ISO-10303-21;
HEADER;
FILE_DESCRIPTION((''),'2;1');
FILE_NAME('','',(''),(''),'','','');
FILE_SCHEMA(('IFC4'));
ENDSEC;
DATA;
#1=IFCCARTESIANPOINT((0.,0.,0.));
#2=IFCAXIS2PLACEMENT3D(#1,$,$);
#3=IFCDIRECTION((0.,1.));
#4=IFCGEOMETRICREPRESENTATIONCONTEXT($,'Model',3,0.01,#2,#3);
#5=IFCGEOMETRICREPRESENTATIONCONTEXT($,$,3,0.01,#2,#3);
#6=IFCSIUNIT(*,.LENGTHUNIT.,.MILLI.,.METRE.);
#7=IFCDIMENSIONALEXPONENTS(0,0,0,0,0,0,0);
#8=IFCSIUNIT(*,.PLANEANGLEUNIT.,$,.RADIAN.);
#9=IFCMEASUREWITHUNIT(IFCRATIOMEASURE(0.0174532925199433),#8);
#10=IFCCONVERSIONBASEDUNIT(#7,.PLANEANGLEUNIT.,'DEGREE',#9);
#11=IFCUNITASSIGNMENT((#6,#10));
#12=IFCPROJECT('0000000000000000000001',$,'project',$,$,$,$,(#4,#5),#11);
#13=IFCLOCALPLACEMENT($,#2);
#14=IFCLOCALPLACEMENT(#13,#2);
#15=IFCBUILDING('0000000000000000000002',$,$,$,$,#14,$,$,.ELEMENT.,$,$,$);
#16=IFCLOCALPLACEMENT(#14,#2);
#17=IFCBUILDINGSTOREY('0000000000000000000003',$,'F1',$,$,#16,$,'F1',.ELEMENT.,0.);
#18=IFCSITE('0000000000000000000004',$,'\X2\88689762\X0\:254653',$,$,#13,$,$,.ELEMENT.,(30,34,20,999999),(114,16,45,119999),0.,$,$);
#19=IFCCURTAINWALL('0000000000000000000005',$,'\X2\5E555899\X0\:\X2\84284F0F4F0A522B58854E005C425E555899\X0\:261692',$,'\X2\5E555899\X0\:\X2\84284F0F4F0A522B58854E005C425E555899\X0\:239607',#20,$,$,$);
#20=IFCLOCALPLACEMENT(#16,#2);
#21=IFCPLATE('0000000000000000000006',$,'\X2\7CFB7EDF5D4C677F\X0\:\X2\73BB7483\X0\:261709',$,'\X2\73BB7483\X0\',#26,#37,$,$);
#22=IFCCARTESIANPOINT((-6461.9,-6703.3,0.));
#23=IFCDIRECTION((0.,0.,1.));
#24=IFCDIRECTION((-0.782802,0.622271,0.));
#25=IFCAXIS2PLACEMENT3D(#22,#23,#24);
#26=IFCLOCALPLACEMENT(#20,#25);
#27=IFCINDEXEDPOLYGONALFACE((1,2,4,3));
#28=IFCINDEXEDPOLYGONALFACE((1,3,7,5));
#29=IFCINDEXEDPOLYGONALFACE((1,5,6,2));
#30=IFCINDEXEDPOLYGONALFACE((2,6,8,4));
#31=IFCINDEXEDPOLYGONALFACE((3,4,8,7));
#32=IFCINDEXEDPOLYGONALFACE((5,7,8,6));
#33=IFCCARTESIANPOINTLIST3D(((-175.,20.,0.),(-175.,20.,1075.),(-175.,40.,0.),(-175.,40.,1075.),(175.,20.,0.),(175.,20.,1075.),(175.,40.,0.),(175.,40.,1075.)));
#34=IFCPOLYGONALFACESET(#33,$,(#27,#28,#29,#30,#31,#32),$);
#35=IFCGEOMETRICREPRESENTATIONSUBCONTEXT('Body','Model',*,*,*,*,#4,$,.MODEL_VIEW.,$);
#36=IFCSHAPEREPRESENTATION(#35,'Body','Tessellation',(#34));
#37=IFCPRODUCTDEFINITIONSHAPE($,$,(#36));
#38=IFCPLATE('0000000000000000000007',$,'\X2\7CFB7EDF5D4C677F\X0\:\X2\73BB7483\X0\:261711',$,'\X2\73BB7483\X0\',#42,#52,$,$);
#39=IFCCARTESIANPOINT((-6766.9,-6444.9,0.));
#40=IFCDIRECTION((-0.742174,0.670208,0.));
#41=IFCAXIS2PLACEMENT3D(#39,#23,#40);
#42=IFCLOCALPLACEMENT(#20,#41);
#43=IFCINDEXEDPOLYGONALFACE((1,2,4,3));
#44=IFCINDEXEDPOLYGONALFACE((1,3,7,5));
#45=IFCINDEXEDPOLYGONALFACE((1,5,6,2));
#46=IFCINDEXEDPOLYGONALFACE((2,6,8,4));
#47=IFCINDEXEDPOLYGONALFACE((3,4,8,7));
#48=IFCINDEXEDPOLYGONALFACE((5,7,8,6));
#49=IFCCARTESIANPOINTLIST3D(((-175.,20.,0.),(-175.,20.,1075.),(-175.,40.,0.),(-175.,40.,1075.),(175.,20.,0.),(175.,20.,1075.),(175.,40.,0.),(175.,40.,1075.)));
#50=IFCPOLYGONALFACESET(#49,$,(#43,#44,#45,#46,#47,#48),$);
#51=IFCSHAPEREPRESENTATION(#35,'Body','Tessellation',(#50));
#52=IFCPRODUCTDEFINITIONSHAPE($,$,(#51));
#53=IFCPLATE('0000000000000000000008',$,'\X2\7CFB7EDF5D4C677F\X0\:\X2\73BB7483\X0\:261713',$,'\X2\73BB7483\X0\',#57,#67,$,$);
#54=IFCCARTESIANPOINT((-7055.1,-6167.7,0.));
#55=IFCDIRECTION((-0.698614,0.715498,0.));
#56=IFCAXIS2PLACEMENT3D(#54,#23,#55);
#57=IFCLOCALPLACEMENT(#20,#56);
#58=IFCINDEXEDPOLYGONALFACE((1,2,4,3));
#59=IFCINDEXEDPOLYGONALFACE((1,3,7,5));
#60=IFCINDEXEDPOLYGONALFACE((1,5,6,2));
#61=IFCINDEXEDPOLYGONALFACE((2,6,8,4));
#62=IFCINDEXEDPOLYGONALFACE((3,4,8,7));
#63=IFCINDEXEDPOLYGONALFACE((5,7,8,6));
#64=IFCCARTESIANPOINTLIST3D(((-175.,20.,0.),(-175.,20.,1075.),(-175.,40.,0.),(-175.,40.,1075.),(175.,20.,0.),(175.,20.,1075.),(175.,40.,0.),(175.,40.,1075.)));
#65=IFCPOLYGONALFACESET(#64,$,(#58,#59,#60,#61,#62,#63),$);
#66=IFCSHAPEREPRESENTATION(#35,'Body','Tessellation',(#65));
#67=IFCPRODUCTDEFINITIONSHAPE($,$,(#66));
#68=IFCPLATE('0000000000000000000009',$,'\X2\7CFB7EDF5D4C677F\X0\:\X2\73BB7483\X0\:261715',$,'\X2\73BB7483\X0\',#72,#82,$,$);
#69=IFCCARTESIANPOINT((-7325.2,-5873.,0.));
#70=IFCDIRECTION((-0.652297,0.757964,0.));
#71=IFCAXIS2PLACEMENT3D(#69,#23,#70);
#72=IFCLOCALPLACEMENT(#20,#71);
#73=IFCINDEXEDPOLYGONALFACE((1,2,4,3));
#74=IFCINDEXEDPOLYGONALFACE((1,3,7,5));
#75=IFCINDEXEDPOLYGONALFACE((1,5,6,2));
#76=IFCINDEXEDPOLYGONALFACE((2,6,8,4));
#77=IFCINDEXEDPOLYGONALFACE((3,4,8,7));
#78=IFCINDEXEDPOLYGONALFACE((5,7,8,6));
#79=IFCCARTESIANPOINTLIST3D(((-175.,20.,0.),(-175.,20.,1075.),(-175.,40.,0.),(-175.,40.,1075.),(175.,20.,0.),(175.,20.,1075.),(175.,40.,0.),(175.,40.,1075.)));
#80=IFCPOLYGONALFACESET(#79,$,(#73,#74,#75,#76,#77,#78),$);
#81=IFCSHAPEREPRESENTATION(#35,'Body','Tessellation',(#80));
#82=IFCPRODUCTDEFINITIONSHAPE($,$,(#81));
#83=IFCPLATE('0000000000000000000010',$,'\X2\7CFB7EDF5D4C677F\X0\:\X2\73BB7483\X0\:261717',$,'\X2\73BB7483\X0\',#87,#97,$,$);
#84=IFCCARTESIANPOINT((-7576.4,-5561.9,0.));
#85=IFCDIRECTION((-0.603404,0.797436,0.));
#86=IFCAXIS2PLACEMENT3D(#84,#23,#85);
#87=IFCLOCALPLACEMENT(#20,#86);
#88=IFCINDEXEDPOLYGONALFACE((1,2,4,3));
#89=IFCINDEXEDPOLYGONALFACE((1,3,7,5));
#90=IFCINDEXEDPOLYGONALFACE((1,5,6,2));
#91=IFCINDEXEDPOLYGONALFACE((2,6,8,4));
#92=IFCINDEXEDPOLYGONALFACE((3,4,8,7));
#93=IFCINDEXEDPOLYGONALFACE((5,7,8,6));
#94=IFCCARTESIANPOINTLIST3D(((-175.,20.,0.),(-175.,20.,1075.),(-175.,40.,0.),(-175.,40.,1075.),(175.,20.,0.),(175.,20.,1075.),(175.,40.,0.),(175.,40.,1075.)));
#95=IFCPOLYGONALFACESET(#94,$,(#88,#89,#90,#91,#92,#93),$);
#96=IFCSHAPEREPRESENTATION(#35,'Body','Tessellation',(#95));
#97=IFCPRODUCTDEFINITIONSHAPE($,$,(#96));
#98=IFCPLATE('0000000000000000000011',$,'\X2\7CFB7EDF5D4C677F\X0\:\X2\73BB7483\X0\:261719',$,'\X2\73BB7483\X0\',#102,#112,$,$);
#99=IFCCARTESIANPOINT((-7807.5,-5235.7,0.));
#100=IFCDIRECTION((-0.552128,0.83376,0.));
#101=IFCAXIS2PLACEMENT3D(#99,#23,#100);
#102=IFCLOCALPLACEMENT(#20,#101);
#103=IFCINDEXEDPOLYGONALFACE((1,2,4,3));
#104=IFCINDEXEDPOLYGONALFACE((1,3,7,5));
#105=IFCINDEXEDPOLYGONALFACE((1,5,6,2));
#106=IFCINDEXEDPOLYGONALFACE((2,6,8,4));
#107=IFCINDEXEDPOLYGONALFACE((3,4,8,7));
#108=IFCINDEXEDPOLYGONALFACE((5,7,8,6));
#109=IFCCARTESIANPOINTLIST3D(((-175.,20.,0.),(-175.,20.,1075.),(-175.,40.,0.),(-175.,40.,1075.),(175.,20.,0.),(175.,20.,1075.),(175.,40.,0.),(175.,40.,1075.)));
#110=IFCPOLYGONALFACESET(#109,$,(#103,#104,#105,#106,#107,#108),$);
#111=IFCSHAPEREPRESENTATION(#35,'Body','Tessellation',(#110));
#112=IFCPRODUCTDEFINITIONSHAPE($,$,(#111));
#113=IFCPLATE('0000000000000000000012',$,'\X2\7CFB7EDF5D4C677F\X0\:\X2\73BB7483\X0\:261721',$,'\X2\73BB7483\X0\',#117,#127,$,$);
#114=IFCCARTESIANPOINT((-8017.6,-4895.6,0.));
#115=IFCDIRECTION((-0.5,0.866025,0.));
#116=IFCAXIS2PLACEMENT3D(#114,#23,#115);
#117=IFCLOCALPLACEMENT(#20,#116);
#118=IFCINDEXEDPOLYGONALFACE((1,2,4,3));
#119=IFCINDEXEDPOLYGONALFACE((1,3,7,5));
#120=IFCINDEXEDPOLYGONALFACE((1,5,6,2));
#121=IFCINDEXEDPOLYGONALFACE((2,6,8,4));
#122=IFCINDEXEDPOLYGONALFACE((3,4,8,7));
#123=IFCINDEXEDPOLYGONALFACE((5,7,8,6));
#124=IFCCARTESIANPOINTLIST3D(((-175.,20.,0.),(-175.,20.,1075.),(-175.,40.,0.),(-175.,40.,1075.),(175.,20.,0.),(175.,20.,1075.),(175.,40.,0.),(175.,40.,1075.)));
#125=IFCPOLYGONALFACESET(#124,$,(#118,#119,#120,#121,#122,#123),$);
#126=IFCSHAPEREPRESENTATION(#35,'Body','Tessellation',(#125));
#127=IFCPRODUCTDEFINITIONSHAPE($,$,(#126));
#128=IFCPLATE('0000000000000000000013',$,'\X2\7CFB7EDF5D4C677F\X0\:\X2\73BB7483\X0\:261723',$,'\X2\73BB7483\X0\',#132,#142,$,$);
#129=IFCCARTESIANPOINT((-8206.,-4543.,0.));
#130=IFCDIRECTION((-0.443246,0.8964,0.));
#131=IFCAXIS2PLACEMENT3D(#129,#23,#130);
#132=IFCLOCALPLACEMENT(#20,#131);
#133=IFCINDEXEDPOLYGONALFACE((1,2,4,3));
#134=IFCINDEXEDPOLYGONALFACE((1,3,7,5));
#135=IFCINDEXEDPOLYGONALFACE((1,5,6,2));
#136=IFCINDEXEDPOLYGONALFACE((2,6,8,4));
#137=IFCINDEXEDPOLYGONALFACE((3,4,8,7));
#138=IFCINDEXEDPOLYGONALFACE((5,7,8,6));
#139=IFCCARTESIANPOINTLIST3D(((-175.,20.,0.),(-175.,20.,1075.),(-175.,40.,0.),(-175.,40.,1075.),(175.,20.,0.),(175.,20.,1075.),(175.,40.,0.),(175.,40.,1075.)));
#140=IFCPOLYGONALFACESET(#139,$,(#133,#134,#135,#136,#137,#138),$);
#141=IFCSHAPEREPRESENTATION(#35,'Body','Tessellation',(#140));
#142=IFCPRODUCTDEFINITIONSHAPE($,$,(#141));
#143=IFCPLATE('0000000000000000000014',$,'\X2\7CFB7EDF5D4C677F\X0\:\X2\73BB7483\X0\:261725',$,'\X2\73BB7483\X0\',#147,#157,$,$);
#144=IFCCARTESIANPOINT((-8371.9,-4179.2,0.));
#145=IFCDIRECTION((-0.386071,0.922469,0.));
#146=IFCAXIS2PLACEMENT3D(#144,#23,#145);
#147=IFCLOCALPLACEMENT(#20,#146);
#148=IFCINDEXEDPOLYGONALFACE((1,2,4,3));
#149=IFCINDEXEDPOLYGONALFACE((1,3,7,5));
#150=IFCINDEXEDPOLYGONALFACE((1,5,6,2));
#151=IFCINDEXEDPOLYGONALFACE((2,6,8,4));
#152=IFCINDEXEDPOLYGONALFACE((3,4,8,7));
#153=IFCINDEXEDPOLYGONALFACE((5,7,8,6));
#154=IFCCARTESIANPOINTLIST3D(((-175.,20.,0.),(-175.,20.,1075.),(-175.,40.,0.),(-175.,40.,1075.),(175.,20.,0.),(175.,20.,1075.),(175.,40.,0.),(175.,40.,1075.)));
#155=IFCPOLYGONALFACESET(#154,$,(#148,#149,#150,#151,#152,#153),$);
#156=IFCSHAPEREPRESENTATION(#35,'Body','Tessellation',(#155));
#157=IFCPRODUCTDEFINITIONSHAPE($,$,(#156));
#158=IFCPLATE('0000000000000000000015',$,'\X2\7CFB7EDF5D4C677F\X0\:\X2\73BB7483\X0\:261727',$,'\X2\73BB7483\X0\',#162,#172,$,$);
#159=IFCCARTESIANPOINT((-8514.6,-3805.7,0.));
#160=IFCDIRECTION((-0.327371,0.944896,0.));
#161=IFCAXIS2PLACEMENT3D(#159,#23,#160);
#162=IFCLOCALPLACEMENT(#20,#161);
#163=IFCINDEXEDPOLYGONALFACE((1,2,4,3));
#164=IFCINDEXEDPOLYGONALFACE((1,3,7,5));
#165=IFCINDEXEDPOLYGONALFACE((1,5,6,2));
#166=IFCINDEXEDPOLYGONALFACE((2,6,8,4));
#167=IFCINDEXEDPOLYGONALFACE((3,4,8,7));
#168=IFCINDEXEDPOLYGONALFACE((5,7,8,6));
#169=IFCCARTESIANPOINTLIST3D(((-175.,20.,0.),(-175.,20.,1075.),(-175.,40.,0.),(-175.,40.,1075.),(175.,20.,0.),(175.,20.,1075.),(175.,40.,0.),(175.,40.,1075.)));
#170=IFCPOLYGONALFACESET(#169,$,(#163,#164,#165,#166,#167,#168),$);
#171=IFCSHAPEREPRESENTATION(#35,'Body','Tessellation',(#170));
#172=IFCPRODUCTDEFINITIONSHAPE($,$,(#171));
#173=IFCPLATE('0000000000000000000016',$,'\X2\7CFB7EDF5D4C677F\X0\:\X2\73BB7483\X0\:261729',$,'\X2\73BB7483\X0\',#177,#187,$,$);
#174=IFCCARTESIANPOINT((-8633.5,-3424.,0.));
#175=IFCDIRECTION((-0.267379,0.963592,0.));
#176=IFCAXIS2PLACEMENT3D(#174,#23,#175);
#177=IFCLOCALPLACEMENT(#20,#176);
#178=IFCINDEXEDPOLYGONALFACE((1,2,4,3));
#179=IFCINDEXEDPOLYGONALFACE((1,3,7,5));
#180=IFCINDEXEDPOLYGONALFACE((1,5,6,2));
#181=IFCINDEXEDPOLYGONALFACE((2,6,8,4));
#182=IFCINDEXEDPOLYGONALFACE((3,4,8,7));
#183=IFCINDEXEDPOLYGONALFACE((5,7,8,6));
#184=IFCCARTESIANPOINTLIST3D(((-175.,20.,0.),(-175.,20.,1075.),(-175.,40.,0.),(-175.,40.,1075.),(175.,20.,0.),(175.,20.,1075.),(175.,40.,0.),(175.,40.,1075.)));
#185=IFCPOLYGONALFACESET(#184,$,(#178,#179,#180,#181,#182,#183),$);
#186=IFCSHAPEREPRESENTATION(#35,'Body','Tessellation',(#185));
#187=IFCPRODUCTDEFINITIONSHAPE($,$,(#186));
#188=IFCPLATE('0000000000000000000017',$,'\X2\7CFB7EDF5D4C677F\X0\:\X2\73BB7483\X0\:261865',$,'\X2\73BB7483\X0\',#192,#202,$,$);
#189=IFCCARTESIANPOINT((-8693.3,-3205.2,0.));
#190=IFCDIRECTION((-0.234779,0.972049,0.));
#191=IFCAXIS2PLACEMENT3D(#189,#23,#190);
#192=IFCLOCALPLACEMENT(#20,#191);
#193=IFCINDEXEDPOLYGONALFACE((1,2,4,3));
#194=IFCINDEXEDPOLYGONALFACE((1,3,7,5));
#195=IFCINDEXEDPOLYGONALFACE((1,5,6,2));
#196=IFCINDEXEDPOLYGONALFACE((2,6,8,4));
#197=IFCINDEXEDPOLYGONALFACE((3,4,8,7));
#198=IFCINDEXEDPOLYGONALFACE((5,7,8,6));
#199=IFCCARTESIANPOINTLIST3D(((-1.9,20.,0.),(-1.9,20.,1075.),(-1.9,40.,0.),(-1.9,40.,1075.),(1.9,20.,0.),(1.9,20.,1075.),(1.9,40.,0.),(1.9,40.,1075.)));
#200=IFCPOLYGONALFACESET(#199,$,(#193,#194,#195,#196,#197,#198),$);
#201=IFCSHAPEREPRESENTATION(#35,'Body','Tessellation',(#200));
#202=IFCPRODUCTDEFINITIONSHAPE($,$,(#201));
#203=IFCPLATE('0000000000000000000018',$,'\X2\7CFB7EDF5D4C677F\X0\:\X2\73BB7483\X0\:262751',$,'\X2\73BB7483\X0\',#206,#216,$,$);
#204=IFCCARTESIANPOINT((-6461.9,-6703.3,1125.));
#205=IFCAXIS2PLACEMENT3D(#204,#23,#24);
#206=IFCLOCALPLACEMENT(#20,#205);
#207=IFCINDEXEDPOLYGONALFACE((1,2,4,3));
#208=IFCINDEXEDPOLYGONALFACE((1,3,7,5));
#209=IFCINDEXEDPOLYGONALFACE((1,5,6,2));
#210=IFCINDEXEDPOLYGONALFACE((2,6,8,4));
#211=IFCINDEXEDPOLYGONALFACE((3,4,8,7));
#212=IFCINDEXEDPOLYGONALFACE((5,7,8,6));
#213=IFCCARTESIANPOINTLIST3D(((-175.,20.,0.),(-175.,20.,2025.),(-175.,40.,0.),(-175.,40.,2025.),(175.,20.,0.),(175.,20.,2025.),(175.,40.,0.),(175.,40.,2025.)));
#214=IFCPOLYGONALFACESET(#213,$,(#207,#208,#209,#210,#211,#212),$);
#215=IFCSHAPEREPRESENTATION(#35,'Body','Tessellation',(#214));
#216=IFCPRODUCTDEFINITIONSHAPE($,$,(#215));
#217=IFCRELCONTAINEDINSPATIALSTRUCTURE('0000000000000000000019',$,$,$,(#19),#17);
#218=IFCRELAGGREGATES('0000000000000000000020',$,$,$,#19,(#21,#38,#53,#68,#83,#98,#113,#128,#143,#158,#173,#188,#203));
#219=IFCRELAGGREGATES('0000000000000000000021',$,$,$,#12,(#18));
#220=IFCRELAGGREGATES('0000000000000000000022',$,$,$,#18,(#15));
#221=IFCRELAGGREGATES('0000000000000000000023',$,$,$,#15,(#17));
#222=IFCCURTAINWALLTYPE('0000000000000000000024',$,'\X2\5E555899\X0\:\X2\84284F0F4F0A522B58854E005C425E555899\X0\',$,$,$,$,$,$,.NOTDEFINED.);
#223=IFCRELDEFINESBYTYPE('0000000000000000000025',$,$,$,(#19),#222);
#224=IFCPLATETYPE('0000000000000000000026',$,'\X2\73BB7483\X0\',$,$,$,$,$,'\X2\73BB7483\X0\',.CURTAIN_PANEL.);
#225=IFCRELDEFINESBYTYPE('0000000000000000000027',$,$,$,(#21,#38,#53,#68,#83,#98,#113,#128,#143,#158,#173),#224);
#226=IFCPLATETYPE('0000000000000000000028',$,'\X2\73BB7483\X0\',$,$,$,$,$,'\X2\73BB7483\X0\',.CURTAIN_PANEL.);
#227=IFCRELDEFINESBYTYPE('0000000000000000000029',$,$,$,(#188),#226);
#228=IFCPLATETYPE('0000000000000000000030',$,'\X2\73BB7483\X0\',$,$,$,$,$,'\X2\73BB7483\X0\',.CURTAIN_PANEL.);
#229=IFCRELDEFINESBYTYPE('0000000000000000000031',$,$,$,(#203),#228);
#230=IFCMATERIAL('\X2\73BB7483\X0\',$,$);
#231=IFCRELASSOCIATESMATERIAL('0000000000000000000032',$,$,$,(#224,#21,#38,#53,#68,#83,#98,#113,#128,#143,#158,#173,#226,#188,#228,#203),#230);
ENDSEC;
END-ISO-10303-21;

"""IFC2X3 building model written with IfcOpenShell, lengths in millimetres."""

from ifc_helpers import new_model, entity, si_unit, converted_unit, direction, frame, frame_2d, origin, place, context, subcontext, project, spatial, rectangle, extrude, source, transform, mapped, material, type_object, type_shapes, element, aggregate, save


model = new_model("IFC2X3")

# Units and contexts
model_context = context("Model", 3, precision=0.01, world=origin(), true_north=direction((0.0, 1.0)))
context_of_model = context(None, 3, precision=0.01, world=origin(), true_north=direction((0.0, 1.0)))
body_context = subcontext(model_context, "Body", "Model", "MODEL_VIEW")
ifc_project = project(units=[si_unit("LENGTHUNIT", "METRE", prefix="MILLI"), converted_unit("PLANEANGLEUNIT", "DEGREE", entity("IfcRatioMeasure", 0.0174532925199433), si_unit("PLANEANGLEUNIT", "RADIAN"), dimensions=[0, 0, 0, 0, 0, 0, 0])], contexts=[model_context, context_of_model])

# Site, building, storey
site_placement = place(None, origin())
site = spatial("IfcSite", under=ifc_project, at=site_placement, Name="表面:254653", CompositionType="ELEMENT", RefLatitude=(30, 34, 20, 999999), RefLongitude=(114, 16, 45, 119999), RefElevation=0.0)
building_placement = place(site_placement, origin())
building = spatial("IfcBuilding", under=site, at=building_placement, CompositionType="ELEMENT")
storey_placement = place(building_placement, origin())
storey = spatial("IfcBuildingStorey", under=building, at=storey_placement, Name="F1", LongName="F1", CompositionType="ELEMENT", Elevation=0.0)

# Curtain wall, plates
curtain_wall_type_1 = type_object("IfcCurtainWallType", Name="幕墙:萨伏伊别墅一层幕墙", PredefinedType="NOTDEFINED")
curtain_wall_1_placement = place(storey_placement, origin())
curtain_wall_1 = element("IfcCurtainWall", 1, at=curtain_wall_1_placement, inside=storey, type_object=curtain_wall_type_1, Name="幕墙:萨伏伊别墅一层幕墙:261692", ObjectType="幕墙:萨伏伊别墅一层幕墙:239607")
ifc_material_1 = material(Name="玻璃")
plate_type_1 = type_object("IfcPlateType", Name="玻璃", ElementType="玻璃", PredefinedType="CURTAIN_PANEL", material=ifc_material_1)
shared_shape_1 = source(origin(), body_context, "Body", "SweptSolid", [
    extrude(rectangle(XDim=20.0, YDim=350.0, at=frame_2d((0.0, 0.0), x_axis=(1.0, 0.0))), frame((0.0, 30.0, 0.0), z_axis=(0.0, 0.0, 1.0), x_axis=(0.0, 1.0, 0.0)), (0.0, 0.0, 1.0), 1075.0),
])
type_shapes(plate_type_1, [shared_shape_1])
plate_1_placement = place(curtain_wall_1_placement, frame((-6461.9, -6703.3, 0.0), z_axis=(0.0, 0.0, 1.0), x_axis=(-0.782802, 0.622271, 0.0)))
plate_1 = element("IfcPlate", 2, at=plate_1_placement, type_object=plate_type_1, material=ifc_material_1, Name="系统嵌板:玻璃:261709", ObjectType="玻璃", context=body_context, shape_type="MappedRepresentation", body=[
    mapped(shared_shape_1, transform((0.0, 0.0, 0.0), scale=1.0)),
])
plate_2_placement = place(curtain_wall_1_placement, frame((-6766.9, -6444.9, 0.0), z_axis=(0.0, 0.0, 1.0), x_axis=(-0.742174, 0.670208, 0.0)))
plate_2 = element("IfcPlate", 3, at=plate_2_placement, type_object=plate_type_1, material=ifc_material_1, Name="系统嵌板:玻璃:261711", ObjectType="玻璃", context=body_context, shape_type="MappedRepresentation", body=[
    mapped(shared_shape_1, transform((0.0, 0.0, 0.0), scale=1.0)),
])
plate_3_placement = place(curtain_wall_1_placement, frame((-7055.1, -6167.7, 0.0), z_axis=(0.0, 0.0, 1.0), x_axis=(-0.698614, 0.715498, 0.0)))
plate_3 = element("IfcPlate", 4, at=plate_3_placement, type_object=plate_type_1, material=ifc_material_1, Name="系统嵌板:玻璃:261713", ObjectType="玻璃", context=body_context, shape_type="MappedRepresentation", body=[
    mapped(shared_shape_1, transform((0.0, 0.0, 0.0), scale=1.0)),
])
plate_4_placement = place(curtain_wall_1_placement, frame((-7325.2, -5873.0, 0.0), z_axis=(0.0, 0.0, 1.0), x_axis=(-0.652297, 0.757964, 0.0)))
plate_4 = element("IfcPlate", 5, at=plate_4_placement, type_object=plate_type_1, material=ifc_material_1, Name="系统嵌板:玻璃:261715", ObjectType="玻璃", context=body_context, shape_type="MappedRepresentation", body=[
    mapped(shared_shape_1, transform((0.0, 0.0, 0.0), scale=1.0)),
])
plate_5_placement = place(curtain_wall_1_placement, frame((-7576.4, -5561.9, 0.0), z_axis=(0.0, 0.0, 1.0), x_axis=(-0.603404, 0.797436, 0.0)))
plate_5 = element("IfcPlate", 6, at=plate_5_placement, type_object=plate_type_1, material=ifc_material_1, Name="系统嵌板:玻璃:261717", ObjectType="玻璃", context=body_context, shape_type="MappedRepresentation", body=[
    mapped(shared_shape_1, transform((0.0, 0.0, 0.0), scale=1.0)),
])
plate_6_placement = place(curtain_wall_1_placement, frame((-7807.5, -5235.7, 0.0), z_axis=(0.0, 0.0, 1.0), x_axis=(-0.552128, 0.83376, 0.0)))
plate_6 = element("IfcPlate", 7, at=plate_6_placement, type_object=plate_type_1, material=ifc_material_1, Name="系统嵌板:玻璃:261719", ObjectType="玻璃", context=body_context, shape_type="MappedRepresentation", body=[
    mapped(shared_shape_1, transform((0.0, 0.0, 0.0), scale=1.0)),
])
plate_7_placement = place(curtain_wall_1_placement, frame((-8017.6, -4895.6, 0.0), z_axis=(0.0, 0.0, 1.0), x_axis=(-0.5, 0.866025, 0.0)))
plate_7 = element("IfcPlate", 8, at=plate_7_placement, type_object=plate_type_1, material=ifc_material_1, Name="系统嵌板:玻璃:261721", ObjectType="玻璃", context=body_context, shape_type="MappedRepresentation", body=[
    mapped(shared_shape_1, transform((0.0, 0.0, 0.0), scale=1.0)),
])
plate_8_placement = place(curtain_wall_1_placement, frame((-8206.0, -4543.0, 0.0), z_axis=(0.0, 0.0, 1.0), x_axis=(-0.443246, 0.8964, 0.0)))
plate_8 = element("IfcPlate", 9, at=plate_8_placement, type_object=plate_type_1, material=ifc_material_1, Name="系统嵌板:玻璃:261723", ObjectType="玻璃", context=body_context, shape_type="MappedRepresentation", body=[
    mapped(shared_shape_1, transform((0.0, 0.0, 0.0), scale=1.0)),
])
plate_9_placement = place(curtain_wall_1_placement, frame((-8371.9, -4179.2, 0.0), z_axis=(0.0, 0.0, 1.0), x_axis=(-0.386071, 0.922469, 0.0)))
plate_9 = element("IfcPlate", 10, at=plate_9_placement, type_object=plate_type_1, material=ifc_material_1, Name="系统嵌板:玻璃:261725", ObjectType="玻璃", context=body_context, shape_type="MappedRepresentation", body=[
    mapped(shared_shape_1, transform((0.0, 0.0, 0.0), scale=1.0)),
])
plate_10_placement = place(curtain_wall_1_placement, frame((-8514.6, -3805.7, 0.0), z_axis=(0.0, 0.0, 1.0), x_axis=(-0.327371, 0.944896, 0.0)))
plate_10 = element("IfcPlate", 11, at=plate_10_placement, type_object=plate_type_1, material=ifc_material_1, Name="系统嵌板:玻璃:261727", ObjectType="玻璃", context=body_context, shape_type="MappedRepresentation", body=[
    mapped(shared_shape_1, transform((0.0, 0.0, 0.0), scale=1.0)),
])
plate_11_placement = place(curtain_wall_1_placement, frame((-8633.5, -3424.0, 0.0), z_axis=(0.0, 0.0, 1.0), x_axis=(-0.267379, 0.963592, 0.0)))
plate_11 = element("IfcPlate", 12, at=plate_11_placement, type_object=plate_type_1, material=ifc_material_1, Name="系统嵌板:玻璃:261729", ObjectType="玻璃", context=body_context, shape_type="MappedRepresentation", body=[
    mapped(shared_shape_1, transform((0.0, 0.0, 0.0), scale=1.0)),
])
plate_type_2 = type_object("IfcPlateType", Name="玻璃", ElementType="玻璃", PredefinedType="CURTAIN_PANEL", material=ifc_material_1)
shared_shape_2 = source(origin(), body_context, "Body", "SweptSolid", [
    extrude(rectangle(XDim=20.0, YDim=3.7, at=frame_2d((0.0, 0.0), x_axis=(1.0, 0.0))), frame((0.0, 30.0, 0.0), z_axis=(0.0, 0.0, 1.0), x_axis=(0.0, 1.0, 0.0)), (0.0, 0.0, 1.0), 1075.0),
])
type_shapes(plate_type_2, [shared_shape_2])
plate_12_placement = place(curtain_wall_1_placement, frame((-8693.3, -3205.2, 0.0), z_axis=(0.0, 0.0, 1.0), x_axis=(-0.234779, 0.972049, 0.0)))
plate_12 = element("IfcPlate", 13, at=plate_12_placement, type_object=plate_type_2, material=ifc_material_1, Name="系统嵌板:玻璃:261865", ObjectType="玻璃", context=body_context, shape_type="MappedRepresentation", body=[
    mapped(shared_shape_2, transform((0.0, 0.0, 0.0), scale=1.0)),
])
plate_type_3 = type_object("IfcPlateType", Name="玻璃", ElementType="玻璃", PredefinedType="CURTAIN_PANEL", material=ifc_material_1)
shared_shape_3 = source(origin(), body_context, "Body", "SweptSolid", [
    extrude(rectangle(XDim=20.0, YDim=350.0, at=frame_2d((0.0, 0.0), x_axis=(1.0, 0.0))), frame((0.0, 30.0, 0.0), z_axis=(0.0, 0.0, 1.0), x_axis=(0.0, 1.0, 0.0)), (0.0, 0.0, 1.0), 2025.0),
])
type_shapes(plate_type_3, [shared_shape_3])
plate_13_placement = place(curtain_wall_1_placement, frame((-6461.9, -6703.3, 1125.0), z_axis=(0.0, 0.0, 1.0), x_axis=(-0.782802, 0.622271, 0.0)))
plate_13 = element("IfcPlate", 14, at=plate_13_placement, type_object=plate_type_3, material=ifc_material_1, Name="系统嵌板:玻璃:262751", ObjectType="玻璃", context=body_context, shape_type="MappedRepresentation", body=[
    mapped(shared_shape_3, transform((0.0, 0.0, 0.0), scale=1.0)),
])
aggregate(curtain_wall_1, [plate_1, plate_2, plate_3, plate_4, plate_5, plate_6, plate_7, plate_8, plate_9, plate_10, plate_11, plate_12, plate_13])

save(model, "model.ifc")
